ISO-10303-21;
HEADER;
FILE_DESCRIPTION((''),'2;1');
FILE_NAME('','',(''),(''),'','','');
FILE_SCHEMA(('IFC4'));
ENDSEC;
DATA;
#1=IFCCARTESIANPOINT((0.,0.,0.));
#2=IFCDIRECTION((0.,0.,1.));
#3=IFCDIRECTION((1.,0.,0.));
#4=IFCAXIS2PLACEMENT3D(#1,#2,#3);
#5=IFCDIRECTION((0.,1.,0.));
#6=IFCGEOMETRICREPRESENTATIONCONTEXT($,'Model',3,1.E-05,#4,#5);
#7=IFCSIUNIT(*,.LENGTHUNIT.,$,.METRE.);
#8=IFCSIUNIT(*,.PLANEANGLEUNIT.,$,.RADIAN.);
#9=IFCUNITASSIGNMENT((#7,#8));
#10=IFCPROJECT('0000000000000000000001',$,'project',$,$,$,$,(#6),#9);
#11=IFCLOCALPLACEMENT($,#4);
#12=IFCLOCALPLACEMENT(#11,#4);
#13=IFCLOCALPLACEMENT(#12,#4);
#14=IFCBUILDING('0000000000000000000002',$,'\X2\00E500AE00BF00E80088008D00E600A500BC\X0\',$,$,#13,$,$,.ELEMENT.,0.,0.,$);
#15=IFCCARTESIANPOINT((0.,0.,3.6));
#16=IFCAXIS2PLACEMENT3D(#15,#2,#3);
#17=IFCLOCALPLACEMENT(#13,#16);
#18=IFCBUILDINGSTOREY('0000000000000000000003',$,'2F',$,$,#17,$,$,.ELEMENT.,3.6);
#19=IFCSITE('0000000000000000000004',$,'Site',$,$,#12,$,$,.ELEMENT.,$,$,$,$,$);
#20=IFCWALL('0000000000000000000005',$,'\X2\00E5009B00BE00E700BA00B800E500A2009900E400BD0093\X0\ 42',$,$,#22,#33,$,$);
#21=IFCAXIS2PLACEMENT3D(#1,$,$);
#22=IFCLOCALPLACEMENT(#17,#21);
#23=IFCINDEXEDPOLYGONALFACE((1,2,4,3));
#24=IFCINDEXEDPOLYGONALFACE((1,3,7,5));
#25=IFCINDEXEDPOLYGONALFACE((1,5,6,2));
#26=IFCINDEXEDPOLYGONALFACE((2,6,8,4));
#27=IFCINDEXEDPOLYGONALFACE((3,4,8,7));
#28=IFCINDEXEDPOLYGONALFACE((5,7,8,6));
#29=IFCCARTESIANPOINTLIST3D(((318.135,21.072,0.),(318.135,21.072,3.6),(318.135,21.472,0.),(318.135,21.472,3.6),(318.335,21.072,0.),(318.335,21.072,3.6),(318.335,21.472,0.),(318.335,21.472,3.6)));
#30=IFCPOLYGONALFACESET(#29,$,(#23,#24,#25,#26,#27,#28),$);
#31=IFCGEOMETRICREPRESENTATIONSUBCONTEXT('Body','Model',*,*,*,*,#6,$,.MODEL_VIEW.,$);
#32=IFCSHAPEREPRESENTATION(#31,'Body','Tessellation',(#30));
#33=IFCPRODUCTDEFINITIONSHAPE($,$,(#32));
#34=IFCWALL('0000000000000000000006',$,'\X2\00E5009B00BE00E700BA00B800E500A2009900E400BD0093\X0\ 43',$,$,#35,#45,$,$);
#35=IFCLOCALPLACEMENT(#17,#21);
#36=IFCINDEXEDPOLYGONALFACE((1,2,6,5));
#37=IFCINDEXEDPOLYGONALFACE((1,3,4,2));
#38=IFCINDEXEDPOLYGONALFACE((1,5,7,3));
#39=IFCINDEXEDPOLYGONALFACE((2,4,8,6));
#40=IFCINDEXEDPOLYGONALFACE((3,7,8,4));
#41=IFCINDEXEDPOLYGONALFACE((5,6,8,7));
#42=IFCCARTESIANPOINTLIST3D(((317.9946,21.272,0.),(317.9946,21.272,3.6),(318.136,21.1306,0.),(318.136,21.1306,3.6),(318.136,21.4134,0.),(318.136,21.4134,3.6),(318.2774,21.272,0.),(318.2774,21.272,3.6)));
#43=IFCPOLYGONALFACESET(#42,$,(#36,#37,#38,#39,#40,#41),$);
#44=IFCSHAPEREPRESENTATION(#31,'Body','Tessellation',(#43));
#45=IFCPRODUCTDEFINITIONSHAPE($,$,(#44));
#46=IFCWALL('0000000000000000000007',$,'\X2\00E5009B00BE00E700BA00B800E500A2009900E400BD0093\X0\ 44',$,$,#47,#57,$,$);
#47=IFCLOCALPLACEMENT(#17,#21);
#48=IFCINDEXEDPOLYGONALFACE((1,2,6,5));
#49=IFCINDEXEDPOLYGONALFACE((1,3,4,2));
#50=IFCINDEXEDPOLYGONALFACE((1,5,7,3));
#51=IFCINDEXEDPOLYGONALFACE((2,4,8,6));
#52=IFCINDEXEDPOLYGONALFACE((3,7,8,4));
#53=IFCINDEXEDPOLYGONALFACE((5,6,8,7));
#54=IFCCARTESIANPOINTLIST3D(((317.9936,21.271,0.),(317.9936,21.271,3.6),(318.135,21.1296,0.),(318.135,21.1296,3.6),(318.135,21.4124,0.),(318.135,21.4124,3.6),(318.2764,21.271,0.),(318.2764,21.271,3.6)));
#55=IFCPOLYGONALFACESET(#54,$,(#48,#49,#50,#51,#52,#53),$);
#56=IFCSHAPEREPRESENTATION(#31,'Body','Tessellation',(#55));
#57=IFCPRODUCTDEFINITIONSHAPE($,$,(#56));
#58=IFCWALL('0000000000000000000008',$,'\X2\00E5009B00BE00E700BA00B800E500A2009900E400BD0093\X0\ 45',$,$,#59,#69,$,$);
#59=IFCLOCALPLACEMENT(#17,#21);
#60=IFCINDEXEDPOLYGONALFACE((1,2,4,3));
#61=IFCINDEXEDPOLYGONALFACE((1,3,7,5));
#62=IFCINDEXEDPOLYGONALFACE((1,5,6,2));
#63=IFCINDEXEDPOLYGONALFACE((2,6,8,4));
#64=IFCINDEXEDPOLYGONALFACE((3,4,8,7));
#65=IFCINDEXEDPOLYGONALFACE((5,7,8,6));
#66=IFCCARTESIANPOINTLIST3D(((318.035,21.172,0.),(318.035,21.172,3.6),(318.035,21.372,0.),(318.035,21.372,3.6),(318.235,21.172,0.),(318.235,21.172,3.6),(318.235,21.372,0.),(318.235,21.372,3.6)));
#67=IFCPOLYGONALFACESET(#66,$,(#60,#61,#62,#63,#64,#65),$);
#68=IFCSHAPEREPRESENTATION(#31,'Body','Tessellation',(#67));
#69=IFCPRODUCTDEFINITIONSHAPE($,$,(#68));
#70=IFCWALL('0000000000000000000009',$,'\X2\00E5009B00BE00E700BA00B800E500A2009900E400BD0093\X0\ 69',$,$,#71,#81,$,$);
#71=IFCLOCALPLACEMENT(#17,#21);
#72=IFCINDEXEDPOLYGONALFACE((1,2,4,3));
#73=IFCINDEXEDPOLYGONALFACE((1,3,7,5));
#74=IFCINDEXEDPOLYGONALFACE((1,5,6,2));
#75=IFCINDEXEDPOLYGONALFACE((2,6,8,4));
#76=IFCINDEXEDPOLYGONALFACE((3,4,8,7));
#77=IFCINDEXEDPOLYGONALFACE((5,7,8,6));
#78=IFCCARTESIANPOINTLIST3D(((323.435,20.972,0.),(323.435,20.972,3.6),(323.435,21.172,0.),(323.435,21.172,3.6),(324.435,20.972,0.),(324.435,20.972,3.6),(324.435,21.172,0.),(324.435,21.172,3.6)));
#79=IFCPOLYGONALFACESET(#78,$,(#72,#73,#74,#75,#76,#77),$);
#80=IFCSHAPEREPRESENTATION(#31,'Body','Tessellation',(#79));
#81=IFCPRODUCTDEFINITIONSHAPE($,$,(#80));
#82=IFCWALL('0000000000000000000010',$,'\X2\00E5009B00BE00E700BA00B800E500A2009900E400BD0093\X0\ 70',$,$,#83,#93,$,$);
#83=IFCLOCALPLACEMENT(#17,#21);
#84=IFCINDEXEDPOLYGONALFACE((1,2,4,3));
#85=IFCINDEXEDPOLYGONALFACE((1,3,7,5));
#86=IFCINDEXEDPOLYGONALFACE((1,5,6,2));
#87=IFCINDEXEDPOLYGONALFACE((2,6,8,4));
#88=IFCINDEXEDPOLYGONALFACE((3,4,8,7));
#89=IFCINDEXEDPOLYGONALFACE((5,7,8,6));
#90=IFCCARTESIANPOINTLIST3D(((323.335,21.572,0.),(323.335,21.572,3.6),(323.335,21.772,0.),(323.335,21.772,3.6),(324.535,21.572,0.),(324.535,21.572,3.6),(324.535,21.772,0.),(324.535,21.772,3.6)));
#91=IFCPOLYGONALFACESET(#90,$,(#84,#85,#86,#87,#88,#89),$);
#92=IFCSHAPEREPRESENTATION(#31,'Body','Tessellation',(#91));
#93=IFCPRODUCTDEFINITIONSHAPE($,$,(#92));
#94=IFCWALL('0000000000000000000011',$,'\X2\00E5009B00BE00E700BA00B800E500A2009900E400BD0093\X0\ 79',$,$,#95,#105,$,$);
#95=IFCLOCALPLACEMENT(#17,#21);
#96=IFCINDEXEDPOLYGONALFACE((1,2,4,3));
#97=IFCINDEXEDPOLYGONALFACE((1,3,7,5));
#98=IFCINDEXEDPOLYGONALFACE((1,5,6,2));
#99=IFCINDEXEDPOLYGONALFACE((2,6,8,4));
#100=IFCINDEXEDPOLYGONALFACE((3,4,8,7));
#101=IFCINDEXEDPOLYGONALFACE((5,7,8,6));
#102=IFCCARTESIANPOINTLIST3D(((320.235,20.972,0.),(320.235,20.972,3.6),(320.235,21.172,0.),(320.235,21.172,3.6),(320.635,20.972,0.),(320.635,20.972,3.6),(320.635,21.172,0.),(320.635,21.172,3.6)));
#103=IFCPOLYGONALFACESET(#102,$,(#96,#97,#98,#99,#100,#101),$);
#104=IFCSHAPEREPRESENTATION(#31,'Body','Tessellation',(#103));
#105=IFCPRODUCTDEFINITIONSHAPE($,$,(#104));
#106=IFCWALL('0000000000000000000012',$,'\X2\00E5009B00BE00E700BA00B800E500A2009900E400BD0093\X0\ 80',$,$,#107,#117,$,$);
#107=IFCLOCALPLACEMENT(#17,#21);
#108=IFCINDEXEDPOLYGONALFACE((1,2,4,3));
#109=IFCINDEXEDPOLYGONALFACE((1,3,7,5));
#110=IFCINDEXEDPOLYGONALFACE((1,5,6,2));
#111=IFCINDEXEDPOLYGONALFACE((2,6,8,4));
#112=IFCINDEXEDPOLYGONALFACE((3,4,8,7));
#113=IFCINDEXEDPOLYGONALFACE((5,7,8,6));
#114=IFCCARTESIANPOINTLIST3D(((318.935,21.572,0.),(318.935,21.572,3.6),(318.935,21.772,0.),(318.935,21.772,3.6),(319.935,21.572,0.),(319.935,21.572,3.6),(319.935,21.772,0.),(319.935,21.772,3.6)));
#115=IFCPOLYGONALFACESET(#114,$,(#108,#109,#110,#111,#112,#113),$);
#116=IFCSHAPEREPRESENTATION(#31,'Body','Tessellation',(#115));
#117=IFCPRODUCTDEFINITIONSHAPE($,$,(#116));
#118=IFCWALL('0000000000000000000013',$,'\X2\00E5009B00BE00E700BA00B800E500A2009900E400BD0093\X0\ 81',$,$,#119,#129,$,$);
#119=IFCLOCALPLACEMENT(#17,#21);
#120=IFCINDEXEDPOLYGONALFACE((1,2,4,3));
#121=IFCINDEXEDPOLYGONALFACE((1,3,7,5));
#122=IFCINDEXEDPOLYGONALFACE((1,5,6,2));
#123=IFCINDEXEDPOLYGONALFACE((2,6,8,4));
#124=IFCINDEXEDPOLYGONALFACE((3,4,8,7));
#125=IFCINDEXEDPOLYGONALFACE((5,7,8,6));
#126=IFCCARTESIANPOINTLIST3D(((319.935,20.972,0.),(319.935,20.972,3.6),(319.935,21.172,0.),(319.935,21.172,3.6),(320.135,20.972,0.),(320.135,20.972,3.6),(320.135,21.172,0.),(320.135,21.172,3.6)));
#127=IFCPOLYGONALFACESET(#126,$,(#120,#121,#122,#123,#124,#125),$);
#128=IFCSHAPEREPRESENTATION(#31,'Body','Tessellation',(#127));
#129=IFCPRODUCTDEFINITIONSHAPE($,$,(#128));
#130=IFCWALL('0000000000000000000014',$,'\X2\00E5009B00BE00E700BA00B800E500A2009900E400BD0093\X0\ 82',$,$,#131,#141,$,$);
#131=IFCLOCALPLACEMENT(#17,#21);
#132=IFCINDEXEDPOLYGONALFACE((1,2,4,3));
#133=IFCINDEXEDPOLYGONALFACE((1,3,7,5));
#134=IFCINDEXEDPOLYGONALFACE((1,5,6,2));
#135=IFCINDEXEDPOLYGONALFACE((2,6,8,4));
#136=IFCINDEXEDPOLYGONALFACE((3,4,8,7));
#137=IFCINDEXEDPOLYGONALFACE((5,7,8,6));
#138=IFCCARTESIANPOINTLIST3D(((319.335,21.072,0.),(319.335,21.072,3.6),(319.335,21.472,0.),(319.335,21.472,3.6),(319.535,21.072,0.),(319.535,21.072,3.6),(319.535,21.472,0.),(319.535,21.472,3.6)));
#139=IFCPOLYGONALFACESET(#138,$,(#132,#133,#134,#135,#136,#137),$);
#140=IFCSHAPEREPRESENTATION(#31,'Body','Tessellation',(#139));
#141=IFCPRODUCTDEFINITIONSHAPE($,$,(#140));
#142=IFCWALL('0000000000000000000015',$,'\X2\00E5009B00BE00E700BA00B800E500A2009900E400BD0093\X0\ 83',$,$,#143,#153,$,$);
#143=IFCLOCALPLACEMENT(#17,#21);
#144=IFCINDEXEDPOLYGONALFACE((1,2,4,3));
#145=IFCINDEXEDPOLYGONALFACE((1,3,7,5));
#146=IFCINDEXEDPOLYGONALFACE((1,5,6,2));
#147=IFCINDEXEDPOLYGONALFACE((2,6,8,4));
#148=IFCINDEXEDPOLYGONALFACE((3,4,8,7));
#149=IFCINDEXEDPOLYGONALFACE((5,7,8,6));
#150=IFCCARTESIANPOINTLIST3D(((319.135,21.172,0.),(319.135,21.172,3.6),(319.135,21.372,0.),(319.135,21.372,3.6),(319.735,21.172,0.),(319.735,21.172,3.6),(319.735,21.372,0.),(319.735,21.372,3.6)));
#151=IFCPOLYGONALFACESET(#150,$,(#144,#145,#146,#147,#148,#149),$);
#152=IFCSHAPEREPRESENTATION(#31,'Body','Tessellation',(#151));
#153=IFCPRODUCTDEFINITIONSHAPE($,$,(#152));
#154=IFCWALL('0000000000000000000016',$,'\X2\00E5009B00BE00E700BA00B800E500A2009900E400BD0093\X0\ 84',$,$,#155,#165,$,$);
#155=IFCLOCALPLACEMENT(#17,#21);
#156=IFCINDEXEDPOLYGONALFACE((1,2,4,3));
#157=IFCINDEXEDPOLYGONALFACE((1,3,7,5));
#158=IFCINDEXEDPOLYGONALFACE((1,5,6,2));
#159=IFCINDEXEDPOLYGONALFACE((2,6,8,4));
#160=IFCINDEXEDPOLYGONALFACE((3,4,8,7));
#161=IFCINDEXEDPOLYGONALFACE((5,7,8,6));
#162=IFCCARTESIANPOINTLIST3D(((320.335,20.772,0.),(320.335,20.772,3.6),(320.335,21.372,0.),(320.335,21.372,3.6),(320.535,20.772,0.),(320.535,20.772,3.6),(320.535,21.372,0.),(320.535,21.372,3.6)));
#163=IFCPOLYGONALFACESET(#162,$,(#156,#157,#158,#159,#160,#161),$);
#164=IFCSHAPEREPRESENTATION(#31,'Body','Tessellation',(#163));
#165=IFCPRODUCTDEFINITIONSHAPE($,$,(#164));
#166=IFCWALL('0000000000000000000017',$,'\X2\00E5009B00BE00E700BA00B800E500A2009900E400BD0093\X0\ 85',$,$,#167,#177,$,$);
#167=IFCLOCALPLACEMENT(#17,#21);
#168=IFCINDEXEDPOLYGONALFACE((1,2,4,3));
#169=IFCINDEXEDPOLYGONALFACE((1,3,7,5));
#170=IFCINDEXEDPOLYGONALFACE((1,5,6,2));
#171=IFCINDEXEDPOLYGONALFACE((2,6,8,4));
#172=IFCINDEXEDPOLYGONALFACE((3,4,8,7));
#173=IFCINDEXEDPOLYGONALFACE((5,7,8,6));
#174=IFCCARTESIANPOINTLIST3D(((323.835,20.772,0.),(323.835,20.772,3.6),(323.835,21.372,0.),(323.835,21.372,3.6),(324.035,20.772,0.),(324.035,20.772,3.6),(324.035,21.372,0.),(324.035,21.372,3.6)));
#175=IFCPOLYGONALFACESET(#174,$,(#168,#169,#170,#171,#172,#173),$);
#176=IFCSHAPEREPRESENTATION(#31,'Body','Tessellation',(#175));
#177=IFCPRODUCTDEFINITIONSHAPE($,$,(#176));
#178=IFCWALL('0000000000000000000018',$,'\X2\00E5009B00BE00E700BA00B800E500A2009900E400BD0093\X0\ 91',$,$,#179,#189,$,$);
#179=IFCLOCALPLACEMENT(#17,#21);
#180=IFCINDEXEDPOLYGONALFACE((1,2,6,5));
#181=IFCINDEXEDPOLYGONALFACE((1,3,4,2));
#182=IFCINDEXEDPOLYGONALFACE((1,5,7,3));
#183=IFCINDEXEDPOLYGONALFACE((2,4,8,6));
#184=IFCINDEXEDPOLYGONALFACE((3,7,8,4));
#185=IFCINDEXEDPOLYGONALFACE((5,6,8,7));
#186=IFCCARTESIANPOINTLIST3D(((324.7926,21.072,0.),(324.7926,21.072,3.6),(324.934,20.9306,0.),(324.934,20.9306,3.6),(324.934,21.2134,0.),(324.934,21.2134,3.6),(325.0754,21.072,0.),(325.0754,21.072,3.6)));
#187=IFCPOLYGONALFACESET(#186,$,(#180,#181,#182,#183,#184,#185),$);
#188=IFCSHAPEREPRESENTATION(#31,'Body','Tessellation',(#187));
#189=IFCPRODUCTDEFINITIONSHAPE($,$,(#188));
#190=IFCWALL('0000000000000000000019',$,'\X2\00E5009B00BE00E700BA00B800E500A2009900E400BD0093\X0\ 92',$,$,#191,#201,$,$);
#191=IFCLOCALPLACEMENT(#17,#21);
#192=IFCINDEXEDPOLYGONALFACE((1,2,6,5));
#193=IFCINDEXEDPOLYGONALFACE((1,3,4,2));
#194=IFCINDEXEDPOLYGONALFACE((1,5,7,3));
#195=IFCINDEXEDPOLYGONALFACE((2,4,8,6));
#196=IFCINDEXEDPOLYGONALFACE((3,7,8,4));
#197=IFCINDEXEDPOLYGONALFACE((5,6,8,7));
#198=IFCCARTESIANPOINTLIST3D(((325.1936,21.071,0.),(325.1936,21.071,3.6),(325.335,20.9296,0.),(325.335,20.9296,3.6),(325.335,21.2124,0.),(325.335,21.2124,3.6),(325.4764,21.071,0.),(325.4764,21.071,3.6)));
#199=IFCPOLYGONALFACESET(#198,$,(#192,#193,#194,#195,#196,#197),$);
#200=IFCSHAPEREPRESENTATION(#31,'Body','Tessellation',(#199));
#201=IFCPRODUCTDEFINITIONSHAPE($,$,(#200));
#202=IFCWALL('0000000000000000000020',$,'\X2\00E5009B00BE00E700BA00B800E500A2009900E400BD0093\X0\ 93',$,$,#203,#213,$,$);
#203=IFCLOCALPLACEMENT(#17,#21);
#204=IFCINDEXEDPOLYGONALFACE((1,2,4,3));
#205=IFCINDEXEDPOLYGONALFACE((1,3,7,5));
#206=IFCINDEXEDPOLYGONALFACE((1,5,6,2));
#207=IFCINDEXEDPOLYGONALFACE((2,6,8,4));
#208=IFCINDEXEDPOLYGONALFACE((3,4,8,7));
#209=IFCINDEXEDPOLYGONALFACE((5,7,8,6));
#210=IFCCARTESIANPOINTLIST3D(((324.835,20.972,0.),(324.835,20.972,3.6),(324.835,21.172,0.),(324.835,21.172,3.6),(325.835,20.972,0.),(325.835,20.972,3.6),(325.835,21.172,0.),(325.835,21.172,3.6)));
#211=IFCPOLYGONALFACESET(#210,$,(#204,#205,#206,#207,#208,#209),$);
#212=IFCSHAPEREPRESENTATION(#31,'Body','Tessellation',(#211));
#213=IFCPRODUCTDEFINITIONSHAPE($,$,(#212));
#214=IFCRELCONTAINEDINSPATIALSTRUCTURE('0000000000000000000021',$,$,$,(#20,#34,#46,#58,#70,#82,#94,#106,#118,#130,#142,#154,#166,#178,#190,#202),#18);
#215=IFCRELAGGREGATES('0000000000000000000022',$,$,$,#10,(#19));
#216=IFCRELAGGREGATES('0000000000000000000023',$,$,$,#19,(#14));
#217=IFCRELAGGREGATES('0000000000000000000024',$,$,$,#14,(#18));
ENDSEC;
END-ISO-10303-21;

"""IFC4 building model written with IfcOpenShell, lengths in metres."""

from ifc_helpers import new_model, si_unit, direction, frame, frame_2d, origin_with_axes, place, context, subcontext, project, spatial, rectangle, extrude, element, save


model = new_model("IFC4")

# Units and contexts
model_context = context("Model", 3, precision=1e-05, world=origin_with_axes(), true_north=direction((0.0, 1.0, 0.0)))
body_context = subcontext(model_context, "Body", "Model", "MODEL_VIEW")
ifc_project = project(units=[si_unit("LENGTHUNIT", "METRE"), si_unit("PLANEANGLEUNIT", "RADIAN")], contexts=[model_context])

# Site, building, storey
placement = place(None, origin_with_axes())
site_placement = place(placement, origin_with_axes())
site = spatial("IfcSite", under=ifc_project, at=site_placement, Name="Site", CompositionType="ELEMENT")
building_placement = place(site_placement, origin_with_axes())
building = spatial("IfcBuilding", under=site, at=building_placement, Name="å®¿è\u0088\u008dæ¥¼", CompositionType="ELEMENT", ElevationOfRefHeight=0.0, ElevationOfTerrain=0.0)
storey_placement = place(building_placement, frame((0.0, 0.0, 3.6), z_axis=(0.0, 0.0, 1.0), x_axis=(1.0, 0.0, 0.0)))
storey = spatial("IfcBuildingStorey", under=building, at=storey_placement, Name="2F", CompositionType="ELEMENT", Elevation=3.6)

# Walls
wall_1_placement = place(storey_placement, frame((318.235, 21.272, 0.0), z_axis=(0.0, 0.0, 1.0), x_axis=(0.0, 1.0, 0.0)))
element("IfcWall", 1, at=wall_1_placement, inside=storey, Name="å\u009b¾çº¸å¢\u0099ä½\u0093 42", context=body_context, shape_type="SweptSolid", body=[
    extrude(rectangle(XDim=0.4, YDim=0.2, at=frame_2d((0.0, 0.0), x_axis=(1.0, 0.0, 0.0))), frame((0.0, 0.0, 0.0), z_axis=(0.0, 0.0, 1.0)), (0.0, 0.0, 1.0), 3.6),
])
for number, where, z_axis, x_axis, name in (
    (2, (318.136, 21.272, 0.0), (0.0, 0.0, 1.0), (-0.707107, -0.707107, 0.0), "å\u009b¾çº¸å¢\u0099ä½\u0093 43"),
    (3, (318.135, 21.271, 0.0), (0.0, 0.0, 1.0), (0.707107, 0.707107, 0.0), "å\u009b¾çº¸å¢\u0099ä½\u0093 44"),
    (4, (318.135, 21.272, 0.0), (0.0, 0.0, 1.0), (1.0, 0.0, 0.0), "å\u009b¾çº¸å¢\u0099ä½\u0093 45"),
):
    element("IfcWall", number, at=place(storey_placement, frame(where, z_axis=z_axis, x_axis=x_axis)), inside=storey, Name=name, context=body_context, shape_type="SweptSolid", body=[
        extrude(rectangle(XDim=0.2, YDim=0.2, at=frame_2d((0.0, 0.0), x_axis=(1.0, 0.0, 0.0))), frame((0.0, 0.0, 0.0), z_axis=(0.0, 0.0, 1.0)), (0.0, 0.0, 1.0), 3.6),
    ])
wall_2_placement = place(storey_placement, frame((323.935, 21.072, 0.0), z_axis=(0.0, 0.0, 1.0), x_axis=(1.0, 0.0, 0.0)))
element("IfcWall", 5, at=wall_2_placement, inside=storey, Name="å\u009b¾çº¸å¢\u0099ä½\u0093 69", context=body_context, shape_type="SweptSolid", body=[
    extrude(rectangle(XDim=1.0, YDim=0.2, at=frame_2d((0.0, 0.0), x_axis=(1.0, 0.0, 0.0))), frame((0.0, 0.0, 0.0), z_axis=(0.0, 0.0, 1.0)), (0.0, 0.0, 1.0), 3.6),
])
wall_3_placement = place(storey_placement, frame((323.935, 21.672, 0.0), z_axis=(0.0, 0.0, 1.0), x_axis=(1.0, 0.0, 0.0)))
element("IfcWall", 6, at=wall_3_placement, inside=storey, Name="å\u009b¾çº¸å¢\u0099ä½\u0093 70", context=body_context, shape_type="SweptSolid", body=[
    extrude(rectangle(XDim=1.2, YDim=0.2, at=frame_2d((0.0, 0.0), x_axis=(1.0, 0.0, 0.0))), frame((0.0, 0.0, 0.0), z_axis=(0.0, 0.0, 1.0)), (0.0, 0.0, 1.0), 3.6),
])
wall_4_placement = place(storey_placement, frame((320.435, 21.072, 0.0), z_axis=(0.0, 0.0, 1.0), x_axis=(-1.0, 0.0, 0.0)))
element("IfcWall", 7, at=wall_4_placement, inside=storey, Name="å\u009b¾çº¸å¢\u0099ä½\u0093 79", context=body_context, shape_type="SweptSolid", body=[
    extrude(rectangle(XDim=0.4, YDim=0.2, at=frame_2d((0.0, 0.0), x_axis=(1.0, 0.0, 0.0))), frame((0.0, 0.0, 0.0), z_axis=(0.0, 0.0, 1.0)), (0.0, 0.0, 1.0), 3.6),
])
wall_5_placement = place(storey_placement, frame((319.435, 21.672, 0.0), z_axis=(0.0, 0.0, 1.0), x_axis=(1.0, 0.0, 0.0)))
element("IfcWall", 8, at=wall_5_placement, inside=storey, Name="å\u009b¾çº¸å¢\u0099ä½\u0093 80", context=body_context, shape_type="SweptSolid", body=[
    extrude(rectangle(XDim=1.0, YDim=0.2, at=frame_2d((0.0, 0.0), x_axis=(1.0, 0.0, 0.0))), frame((0.0, 0.0, 0.0), z_axis=(0.0, 0.0, 1.0)), (0.0, 0.0, 1.0), 3.6),
])
wall_6_placement = place(storey_placement, frame((320.035, 21.072, 0.0), z_axis=(0.0, 0.0, 1.0), x_axis=(0.0, 1.0, 0.0)))
element("IfcWall", 9, at=wall_6_placement, inside=storey, Name="å\u009b¾çº¸å¢\u0099ä½\u0093 81", context=body_context, shape_type="SweptSolid", body=[
    extrude(rectangle(XDim=0.2, YDim=0.2, at=frame_2d((0.0, 0.0), x_axis=(1.0, 0.0, 0.0))), frame((0.0, 0.0, 0.0), z_axis=(0.0, 0.0, 1.0)), (0.0, 0.0, 1.0), 3.6),
])
wall_7_placement = place(storey_placement, frame((319.435, 21.272, 0.0), z_axis=(0.0, 0.0, 1.0), x_axis=(0.0, 1.0, 0.0)))
element("IfcWall", 10, at=wall_7_placement, inside=storey, Name="å\u009b¾çº¸å¢\u0099ä½\u0093 82", context=body_context, shape_type="SweptSolid", body=[
    extrude(rectangle(XDim=0.4, YDim=0.2, at=frame_2d((0.0, 0.0), x_axis=(1.0, 0.0, 0.0))), frame((0.0, 0.0, 0.0), z_axis=(0.0, 0.0, 1.0)), (0.0, 0.0, 1.0), 3.6),
])
for number, where, z_axis, x_axis, name in (
    (11, (319.435, 21.272, 0.0), (0.0, 0.0, 1.0), (1.0, 0.0, 0.0), "å\u009b¾çº¸å¢\u0099ä½\u0093 83"),
    (12, (320.435, 21.072, 0.0), (0.0, 0.0, 1.0), (0.0, 1.0, 0.0), "å\u009b¾çº¸å¢\u0099ä½\u0093 84"),
    (13, (323.935, 21.072, 0.0), (0.0, 0.0, 1.0), (0.0, 1.0, 0.0), "å\u009b¾çº¸å¢\u0099ä½\u0093 85"),
):
    element("IfcWall", number, at=place(storey_placement, frame(where, z_axis=z_axis, x_axis=x_axis)), inside=storey, Name=name, context=body_context, shape_type="SweptSolid", body=[
        extrude(rectangle(XDim=0.6, YDim=0.2, at=frame_2d((0.0, 0.0), x_axis=(1.0, 0.0, 0.0))), frame((0.0, 0.0, 0.0), z_axis=(0.0, 0.0, 1.0)), (0.0, 0.0, 1.0), 3.6),
    ])
for number, where, z_axis, x_axis, name in (
    (14, (324.934, 21.072, 0.0), (0.0, 0.0, 1.0), (0.707107, -0.707107, 0.0), "å\u009b¾çº¸å¢\u0099ä½\u0093 91"),
    (15, (325.335, 21.071, 0.0), (0.0, 0.0, 1.0), (0.707107, 0.707107, 0.0), "å\u009b¾çº¸å¢\u0099ä½\u0093 92"),
):
    element("IfcWall", number, at=place(storey_placement, frame(where, z_axis=z_axis, x_axis=x_axis)), inside=storey, Name=name, context=body_context, shape_type="SweptSolid", body=[
        extrude(rectangle(XDim=0.2, YDim=0.2, at=frame_2d((0.0, 0.0), x_axis=(1.0, 0.0, 0.0))), frame((0.0, 0.0, 0.0), z_axis=(0.0, 0.0, 1.0)), (0.0, 0.0, 1.0), 3.6),
    ])
wall_8_placement = place(storey_placement, frame((325.335, 21.072, 0.0), z_axis=(0.0, 0.0, 1.0), x_axis=(1.0, 0.0, 0.0)))
element("IfcWall", 16, at=wall_8_placement, inside=storey, Name="å\u009b¾çº¸å¢\u0099ä½\u0093 93", context=body_context, shape_type="SweptSolid", body=[
    extrude(rectangle(XDim=1.0, YDim=0.2, at=frame_2d((0.0, 0.0), x_axis=(1.0, 0.0, 0.0))), frame((0.0, 0.0, 0.0), z_axis=(0.0, 0.0, 1.0)), (0.0, 0.0, 1.0), 3.6),
])

save(model, "model.ifc")
